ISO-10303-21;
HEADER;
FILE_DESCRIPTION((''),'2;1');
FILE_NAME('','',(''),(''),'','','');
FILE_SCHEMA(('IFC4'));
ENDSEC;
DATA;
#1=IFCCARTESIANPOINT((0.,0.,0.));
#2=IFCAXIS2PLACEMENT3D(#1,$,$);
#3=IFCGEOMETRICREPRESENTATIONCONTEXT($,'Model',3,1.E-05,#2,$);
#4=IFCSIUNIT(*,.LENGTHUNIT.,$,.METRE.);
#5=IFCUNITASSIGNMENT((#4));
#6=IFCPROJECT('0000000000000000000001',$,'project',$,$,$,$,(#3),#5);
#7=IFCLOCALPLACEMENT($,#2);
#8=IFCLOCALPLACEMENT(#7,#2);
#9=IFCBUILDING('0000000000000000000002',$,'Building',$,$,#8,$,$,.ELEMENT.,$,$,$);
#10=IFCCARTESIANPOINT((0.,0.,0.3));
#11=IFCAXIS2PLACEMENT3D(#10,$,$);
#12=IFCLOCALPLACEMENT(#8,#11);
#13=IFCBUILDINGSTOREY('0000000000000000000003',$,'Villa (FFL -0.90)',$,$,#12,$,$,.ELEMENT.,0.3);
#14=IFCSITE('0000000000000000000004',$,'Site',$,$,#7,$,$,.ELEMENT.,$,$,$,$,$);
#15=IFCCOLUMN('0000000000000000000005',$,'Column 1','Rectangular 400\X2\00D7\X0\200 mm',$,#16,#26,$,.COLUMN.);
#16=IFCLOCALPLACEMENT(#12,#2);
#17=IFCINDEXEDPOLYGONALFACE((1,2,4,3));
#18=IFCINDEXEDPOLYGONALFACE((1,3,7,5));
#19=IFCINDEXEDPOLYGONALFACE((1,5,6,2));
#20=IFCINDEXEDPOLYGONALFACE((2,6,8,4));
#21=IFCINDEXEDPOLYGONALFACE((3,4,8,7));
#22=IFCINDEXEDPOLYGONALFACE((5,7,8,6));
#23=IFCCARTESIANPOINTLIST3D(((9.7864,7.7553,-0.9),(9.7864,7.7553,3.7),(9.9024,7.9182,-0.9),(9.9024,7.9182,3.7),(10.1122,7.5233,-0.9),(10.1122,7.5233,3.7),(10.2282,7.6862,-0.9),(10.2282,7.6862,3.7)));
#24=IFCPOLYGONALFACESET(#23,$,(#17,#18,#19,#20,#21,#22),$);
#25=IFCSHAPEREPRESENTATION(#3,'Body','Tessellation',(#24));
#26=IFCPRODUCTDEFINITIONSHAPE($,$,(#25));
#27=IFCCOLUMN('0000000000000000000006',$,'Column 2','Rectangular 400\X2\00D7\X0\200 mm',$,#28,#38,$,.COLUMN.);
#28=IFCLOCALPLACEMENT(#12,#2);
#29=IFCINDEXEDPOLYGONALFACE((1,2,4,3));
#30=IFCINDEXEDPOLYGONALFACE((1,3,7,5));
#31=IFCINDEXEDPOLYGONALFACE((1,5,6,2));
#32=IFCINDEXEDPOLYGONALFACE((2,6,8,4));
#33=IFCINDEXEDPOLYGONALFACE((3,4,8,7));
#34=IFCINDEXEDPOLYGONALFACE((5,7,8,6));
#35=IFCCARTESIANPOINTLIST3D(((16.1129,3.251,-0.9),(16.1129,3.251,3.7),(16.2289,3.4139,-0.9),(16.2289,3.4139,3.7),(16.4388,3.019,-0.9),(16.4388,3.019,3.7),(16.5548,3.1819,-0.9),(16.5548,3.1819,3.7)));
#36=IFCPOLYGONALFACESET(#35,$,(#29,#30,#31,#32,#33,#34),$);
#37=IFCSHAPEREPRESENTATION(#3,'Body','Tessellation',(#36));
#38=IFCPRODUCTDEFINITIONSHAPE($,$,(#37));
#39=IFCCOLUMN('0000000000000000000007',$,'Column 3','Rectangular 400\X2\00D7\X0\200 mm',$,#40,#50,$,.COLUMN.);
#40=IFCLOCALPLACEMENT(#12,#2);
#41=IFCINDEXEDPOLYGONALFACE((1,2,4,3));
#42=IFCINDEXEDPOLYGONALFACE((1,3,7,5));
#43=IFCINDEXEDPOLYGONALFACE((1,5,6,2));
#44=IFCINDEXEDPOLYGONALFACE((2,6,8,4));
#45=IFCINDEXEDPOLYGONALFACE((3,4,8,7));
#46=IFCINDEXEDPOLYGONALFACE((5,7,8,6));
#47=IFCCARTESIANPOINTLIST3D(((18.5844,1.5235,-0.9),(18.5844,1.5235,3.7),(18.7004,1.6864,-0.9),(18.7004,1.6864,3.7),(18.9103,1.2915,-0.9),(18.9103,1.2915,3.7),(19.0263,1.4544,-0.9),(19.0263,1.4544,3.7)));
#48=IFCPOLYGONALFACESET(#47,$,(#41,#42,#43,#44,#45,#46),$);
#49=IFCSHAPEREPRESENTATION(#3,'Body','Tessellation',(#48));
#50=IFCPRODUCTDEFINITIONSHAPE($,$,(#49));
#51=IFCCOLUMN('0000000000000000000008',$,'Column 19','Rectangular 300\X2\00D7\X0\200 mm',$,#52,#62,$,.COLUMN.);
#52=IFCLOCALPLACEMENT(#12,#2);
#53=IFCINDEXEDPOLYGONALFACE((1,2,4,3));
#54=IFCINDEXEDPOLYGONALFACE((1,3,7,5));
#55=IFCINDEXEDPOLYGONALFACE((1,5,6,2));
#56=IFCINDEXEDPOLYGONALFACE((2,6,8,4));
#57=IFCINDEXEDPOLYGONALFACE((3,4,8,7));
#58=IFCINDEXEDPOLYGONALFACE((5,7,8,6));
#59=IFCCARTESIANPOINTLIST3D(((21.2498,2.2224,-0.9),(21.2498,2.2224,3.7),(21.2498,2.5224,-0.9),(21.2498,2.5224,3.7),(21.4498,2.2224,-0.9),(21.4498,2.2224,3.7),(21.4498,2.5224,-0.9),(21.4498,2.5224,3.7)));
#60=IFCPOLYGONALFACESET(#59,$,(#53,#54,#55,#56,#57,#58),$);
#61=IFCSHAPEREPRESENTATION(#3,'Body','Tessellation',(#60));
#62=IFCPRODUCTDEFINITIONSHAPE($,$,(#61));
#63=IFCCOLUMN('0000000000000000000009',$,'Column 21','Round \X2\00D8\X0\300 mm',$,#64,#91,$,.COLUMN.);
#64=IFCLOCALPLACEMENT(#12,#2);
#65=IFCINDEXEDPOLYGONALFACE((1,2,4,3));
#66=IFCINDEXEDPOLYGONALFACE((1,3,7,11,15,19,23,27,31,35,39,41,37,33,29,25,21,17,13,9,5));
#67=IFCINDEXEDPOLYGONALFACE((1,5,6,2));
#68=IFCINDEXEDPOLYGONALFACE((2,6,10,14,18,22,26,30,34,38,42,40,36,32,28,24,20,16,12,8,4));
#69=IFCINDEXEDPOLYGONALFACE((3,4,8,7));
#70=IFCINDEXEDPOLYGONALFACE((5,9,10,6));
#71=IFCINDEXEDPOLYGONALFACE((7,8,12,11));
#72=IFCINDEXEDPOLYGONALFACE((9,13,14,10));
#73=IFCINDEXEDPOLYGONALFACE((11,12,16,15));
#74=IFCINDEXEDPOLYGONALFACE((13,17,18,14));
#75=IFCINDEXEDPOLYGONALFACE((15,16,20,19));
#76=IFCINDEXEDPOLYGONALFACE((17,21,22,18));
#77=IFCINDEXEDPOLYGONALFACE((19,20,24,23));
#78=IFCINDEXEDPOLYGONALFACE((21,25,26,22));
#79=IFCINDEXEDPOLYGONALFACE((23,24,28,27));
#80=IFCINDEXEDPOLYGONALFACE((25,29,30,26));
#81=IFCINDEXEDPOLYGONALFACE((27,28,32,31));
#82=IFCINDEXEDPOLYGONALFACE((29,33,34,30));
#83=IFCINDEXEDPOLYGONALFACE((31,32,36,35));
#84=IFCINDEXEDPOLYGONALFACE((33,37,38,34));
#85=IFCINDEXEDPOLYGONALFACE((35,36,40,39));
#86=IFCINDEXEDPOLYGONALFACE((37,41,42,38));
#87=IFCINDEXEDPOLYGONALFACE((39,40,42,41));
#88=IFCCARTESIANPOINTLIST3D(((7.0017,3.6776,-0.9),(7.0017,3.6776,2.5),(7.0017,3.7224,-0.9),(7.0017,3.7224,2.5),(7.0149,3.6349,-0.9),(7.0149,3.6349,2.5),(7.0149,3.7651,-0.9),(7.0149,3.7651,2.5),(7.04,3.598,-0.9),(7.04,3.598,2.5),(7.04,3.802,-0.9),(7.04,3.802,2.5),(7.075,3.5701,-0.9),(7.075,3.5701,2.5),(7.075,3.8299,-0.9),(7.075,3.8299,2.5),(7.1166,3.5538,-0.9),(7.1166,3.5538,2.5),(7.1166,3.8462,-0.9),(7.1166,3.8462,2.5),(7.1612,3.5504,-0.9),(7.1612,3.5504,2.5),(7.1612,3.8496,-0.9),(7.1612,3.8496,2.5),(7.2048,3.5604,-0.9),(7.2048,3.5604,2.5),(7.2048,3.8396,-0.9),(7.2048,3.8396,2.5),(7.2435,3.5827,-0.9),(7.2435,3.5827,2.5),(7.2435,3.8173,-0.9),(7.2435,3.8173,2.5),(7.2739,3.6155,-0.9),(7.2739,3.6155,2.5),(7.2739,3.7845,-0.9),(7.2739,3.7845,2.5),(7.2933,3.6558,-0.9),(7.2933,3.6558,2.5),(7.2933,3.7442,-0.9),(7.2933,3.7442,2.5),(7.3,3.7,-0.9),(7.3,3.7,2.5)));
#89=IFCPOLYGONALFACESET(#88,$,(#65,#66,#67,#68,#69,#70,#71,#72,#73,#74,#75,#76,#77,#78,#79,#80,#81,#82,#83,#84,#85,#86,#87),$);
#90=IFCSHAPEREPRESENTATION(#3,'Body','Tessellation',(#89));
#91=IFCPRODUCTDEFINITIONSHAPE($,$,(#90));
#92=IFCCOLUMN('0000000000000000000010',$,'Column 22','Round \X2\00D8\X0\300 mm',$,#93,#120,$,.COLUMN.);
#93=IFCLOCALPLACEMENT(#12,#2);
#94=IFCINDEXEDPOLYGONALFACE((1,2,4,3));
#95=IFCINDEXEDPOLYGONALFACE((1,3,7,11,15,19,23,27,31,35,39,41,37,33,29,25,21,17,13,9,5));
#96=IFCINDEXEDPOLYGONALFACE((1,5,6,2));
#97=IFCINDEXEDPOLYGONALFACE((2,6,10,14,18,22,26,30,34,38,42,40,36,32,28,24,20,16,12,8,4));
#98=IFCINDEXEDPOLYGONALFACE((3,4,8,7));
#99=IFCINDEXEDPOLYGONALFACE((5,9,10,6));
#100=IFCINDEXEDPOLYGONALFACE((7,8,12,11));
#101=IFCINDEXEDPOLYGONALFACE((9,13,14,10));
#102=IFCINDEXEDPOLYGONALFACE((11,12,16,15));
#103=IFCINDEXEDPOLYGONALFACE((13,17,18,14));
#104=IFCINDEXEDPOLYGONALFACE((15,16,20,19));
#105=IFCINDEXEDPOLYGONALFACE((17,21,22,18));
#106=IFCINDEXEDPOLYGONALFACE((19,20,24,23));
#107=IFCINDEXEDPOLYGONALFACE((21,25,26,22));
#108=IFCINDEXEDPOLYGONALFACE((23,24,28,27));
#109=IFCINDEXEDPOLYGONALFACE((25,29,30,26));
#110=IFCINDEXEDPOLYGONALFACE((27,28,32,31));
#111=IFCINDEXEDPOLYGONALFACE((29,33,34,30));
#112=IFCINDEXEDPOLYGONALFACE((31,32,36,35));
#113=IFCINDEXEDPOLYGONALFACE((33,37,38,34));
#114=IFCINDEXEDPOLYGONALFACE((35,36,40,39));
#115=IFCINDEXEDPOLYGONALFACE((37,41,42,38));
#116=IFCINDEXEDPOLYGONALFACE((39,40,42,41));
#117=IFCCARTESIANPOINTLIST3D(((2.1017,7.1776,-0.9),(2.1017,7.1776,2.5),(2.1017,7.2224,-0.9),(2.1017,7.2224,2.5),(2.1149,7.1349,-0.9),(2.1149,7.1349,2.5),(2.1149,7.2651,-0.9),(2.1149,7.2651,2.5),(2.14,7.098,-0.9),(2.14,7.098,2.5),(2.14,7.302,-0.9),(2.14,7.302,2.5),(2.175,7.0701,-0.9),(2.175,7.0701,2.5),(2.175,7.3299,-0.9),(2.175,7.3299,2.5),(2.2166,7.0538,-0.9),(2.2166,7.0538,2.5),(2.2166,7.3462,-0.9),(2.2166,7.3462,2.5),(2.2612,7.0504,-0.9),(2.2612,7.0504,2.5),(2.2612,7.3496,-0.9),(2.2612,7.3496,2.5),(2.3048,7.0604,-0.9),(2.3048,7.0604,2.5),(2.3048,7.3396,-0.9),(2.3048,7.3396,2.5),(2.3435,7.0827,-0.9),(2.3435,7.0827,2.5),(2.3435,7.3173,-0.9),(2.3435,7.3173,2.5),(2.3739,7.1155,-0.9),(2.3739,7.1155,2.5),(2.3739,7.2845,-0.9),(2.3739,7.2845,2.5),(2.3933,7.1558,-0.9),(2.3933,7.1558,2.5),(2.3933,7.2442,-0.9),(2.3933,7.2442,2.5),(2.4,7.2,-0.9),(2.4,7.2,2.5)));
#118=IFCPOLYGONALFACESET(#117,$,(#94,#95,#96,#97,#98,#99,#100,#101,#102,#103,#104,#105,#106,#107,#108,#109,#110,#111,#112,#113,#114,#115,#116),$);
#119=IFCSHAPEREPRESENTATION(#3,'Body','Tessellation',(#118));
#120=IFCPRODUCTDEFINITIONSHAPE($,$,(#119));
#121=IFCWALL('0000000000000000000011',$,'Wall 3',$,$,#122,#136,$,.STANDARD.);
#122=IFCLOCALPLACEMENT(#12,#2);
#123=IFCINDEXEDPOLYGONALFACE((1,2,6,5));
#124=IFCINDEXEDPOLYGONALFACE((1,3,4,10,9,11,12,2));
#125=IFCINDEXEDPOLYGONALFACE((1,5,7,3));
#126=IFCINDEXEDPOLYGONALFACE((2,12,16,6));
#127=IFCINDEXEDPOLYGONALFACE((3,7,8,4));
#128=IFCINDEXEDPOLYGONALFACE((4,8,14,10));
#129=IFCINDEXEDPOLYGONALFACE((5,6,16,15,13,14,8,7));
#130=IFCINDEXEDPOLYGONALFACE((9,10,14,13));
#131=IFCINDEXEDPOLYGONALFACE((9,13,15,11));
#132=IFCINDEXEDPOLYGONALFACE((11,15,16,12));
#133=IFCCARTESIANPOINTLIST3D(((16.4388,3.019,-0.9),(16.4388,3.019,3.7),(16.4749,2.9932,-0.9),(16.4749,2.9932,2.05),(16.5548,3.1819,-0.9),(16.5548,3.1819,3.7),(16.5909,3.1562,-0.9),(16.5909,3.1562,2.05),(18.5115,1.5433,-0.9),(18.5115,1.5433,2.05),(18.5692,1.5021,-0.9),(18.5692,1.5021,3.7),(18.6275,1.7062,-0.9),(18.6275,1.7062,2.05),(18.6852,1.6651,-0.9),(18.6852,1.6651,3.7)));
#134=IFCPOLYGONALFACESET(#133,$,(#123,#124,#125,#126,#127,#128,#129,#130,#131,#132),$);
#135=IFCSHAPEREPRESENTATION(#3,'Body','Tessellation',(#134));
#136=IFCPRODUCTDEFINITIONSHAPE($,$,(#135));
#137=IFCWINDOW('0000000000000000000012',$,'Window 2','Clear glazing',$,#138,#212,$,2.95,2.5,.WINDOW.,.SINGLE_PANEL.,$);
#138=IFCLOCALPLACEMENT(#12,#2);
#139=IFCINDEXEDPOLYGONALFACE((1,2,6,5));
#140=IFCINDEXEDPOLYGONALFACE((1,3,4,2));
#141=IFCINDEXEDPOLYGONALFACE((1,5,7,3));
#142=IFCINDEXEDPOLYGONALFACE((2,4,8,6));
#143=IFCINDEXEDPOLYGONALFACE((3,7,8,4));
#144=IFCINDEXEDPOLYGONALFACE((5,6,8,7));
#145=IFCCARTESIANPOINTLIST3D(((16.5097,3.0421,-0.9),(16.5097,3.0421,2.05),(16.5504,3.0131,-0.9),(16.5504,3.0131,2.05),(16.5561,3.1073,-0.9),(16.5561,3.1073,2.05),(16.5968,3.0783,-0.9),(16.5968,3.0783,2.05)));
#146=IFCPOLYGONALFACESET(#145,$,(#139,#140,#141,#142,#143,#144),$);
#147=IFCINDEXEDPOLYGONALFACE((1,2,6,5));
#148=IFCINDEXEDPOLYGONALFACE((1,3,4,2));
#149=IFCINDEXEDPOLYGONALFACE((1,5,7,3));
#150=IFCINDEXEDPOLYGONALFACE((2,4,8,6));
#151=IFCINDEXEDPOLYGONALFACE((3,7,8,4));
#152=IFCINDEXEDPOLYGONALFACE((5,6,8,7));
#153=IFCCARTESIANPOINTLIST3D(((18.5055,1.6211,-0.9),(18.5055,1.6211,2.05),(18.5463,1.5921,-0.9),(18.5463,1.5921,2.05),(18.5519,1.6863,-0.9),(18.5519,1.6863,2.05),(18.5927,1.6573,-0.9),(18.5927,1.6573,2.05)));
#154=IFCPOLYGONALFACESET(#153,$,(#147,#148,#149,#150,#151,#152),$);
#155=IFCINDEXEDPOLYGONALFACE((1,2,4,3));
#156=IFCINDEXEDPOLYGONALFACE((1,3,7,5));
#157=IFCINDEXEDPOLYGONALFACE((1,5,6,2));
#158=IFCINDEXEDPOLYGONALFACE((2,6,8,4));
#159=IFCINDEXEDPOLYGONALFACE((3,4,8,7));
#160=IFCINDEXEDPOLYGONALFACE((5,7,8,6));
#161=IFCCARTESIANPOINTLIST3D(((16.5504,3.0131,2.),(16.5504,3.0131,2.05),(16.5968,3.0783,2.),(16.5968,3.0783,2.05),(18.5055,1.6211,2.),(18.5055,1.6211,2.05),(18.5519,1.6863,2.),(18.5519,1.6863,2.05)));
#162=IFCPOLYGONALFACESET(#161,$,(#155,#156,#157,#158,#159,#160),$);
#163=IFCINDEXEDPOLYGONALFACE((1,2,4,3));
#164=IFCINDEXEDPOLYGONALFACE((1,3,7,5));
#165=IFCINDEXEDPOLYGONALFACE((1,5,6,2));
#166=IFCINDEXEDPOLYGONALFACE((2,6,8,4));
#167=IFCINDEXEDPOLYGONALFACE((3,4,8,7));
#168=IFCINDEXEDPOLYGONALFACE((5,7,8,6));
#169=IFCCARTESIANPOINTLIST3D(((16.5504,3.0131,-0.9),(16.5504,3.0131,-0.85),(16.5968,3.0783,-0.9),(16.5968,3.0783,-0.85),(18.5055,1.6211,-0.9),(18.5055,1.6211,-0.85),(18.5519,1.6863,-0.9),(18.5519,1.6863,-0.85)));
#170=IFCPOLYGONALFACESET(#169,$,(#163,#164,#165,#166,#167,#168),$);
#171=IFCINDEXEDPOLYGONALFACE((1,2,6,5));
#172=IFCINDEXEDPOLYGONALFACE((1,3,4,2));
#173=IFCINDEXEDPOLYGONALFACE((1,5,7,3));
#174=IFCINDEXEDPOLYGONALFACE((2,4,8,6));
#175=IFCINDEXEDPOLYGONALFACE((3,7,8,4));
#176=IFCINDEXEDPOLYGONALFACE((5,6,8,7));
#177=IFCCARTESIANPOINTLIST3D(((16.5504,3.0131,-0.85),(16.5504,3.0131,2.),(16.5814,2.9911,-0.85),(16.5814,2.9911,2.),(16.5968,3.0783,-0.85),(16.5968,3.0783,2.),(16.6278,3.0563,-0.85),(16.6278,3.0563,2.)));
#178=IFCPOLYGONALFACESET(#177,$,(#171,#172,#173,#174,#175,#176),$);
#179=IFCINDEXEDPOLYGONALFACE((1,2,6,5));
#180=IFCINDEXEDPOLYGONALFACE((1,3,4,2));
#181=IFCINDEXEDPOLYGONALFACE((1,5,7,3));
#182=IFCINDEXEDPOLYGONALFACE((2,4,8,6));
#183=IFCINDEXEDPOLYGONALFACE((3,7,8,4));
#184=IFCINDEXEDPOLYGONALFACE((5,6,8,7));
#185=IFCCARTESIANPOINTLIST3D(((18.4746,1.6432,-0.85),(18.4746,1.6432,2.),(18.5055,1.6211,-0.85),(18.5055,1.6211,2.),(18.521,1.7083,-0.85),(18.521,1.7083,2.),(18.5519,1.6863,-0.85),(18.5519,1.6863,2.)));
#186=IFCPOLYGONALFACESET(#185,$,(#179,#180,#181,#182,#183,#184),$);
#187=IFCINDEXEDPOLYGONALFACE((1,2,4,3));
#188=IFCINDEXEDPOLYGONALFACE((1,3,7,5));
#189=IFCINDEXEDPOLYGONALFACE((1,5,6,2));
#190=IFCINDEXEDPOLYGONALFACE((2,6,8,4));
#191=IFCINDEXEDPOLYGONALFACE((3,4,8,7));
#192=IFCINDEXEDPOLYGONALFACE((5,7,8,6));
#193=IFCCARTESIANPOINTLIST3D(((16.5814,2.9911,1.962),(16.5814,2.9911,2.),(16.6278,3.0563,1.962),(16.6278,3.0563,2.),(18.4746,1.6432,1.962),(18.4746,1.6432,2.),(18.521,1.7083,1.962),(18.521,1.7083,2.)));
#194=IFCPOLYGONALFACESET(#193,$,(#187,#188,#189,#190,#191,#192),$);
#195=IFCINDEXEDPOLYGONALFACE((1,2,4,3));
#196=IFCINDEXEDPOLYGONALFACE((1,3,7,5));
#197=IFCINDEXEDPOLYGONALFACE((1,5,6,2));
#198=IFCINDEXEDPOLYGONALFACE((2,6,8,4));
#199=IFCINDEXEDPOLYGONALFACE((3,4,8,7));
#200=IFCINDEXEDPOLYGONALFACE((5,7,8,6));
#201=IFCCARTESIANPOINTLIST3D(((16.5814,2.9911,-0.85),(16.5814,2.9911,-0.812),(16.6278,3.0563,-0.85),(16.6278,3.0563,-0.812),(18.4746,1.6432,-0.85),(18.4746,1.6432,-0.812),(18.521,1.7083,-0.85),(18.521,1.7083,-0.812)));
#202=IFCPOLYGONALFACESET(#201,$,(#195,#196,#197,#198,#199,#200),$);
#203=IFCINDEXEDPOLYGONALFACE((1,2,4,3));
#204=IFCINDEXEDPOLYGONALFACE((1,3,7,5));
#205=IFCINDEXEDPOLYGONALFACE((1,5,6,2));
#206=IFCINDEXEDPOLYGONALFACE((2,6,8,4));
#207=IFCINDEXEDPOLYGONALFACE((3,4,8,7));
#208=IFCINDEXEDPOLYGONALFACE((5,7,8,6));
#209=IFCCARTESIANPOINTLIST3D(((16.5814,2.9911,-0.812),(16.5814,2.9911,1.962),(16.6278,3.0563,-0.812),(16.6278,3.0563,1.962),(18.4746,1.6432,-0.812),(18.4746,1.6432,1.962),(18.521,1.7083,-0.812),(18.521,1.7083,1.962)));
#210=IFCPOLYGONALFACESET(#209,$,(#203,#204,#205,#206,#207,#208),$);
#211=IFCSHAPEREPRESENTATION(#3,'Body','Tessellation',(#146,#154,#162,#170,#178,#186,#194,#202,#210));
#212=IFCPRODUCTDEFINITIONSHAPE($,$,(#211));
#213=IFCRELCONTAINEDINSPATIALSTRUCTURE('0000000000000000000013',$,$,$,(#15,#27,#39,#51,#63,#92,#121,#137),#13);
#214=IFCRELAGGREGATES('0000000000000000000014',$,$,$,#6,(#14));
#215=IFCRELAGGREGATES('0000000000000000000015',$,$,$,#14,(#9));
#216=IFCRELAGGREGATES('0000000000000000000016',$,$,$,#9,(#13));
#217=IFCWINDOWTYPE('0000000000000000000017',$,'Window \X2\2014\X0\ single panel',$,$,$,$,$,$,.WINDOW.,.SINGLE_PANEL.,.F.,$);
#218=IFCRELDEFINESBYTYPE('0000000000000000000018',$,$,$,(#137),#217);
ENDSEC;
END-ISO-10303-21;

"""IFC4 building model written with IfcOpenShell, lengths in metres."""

from ifc_helpers import new_model, si_unit, frame, frame_2d, origin, origin_2d, place, context, project, spatial, polyline, rectangle, circle, outline, extrude, type_object, element, fill, save


model = new_model("IFC4")

# Units and contexts
model_context = context("Model", 3, precision=1e-05, world=origin())
ifc_project = project(units=[si_unit("LENGTHUNIT", "METRE")], contexts=[model_context])

# Site, building, storey
site_placement = place(None, origin())
site = spatial("IfcSite", under=ifc_project, at=site_placement, Name="Site", CompositionType="ELEMENT")
building_placement = place(site_placement, origin())
building = spatial("IfcBuilding", under=site, at=building_placement, Name="Building", CompositionType="ELEMENT")
storey_placement = place(building_placement, frame((0.0, 0.0, 0.3)))
storey = spatial("IfcBuildingStorey", under=building, at=storey_placement, Name="Villa (FFL -0.90)", CompositionType="ELEMENT", Elevation=0.3)

# Columns
for number, where, z_axis, x_axis, name in (
    (1, (10.0073, 7.7208, -0.9), (0.0, 0.0, 1.0), (0.814622, -0.579992, 0.0), "Column 1"),
    (2, (16.3339, 3.2164, -0.9), (0.0, 0.0, 1.0), (0.814622, -0.579992, 0.0), "Column 2"),
    (3, (18.8054, 1.489, -0.9), (0.0, 0.0, 1.0), (0.814622, -0.579992, 0.0), "Column 3"),
):
    element("IfcColumn", number, at=place(storey_placement, frame(where, z_axis=z_axis, x_axis=x_axis)), inside=storey, Name=name, Description="Rectangular 400×200 mm", PredefinedType="COLUMN", context=model_context, shape_type="SweptSolid", body=[
        extrude(outline(polyline([(-0.2, -0.1), (0.2, -0.1), (0.2, 0.1), (-0.2, 0.1), (-0.2, -0.1)])), origin(), (0.0, 0.0, 1.0), 4.6),
    ])
column_placement = place(storey_placement, frame((21.3498, 2.3724, -0.9), z_axis=(0.0, 0.0, 1.0), x_axis=(0.0, 1.0, 0.0)))
element("IfcColumn", 4, at=column_placement, inside=storey, Name="Column 19", Description="Rectangular 300×200 mm", PredefinedType="COLUMN", context=model_context, shape_type="SweptSolid", body=[
    extrude(outline(polyline([(-0.15, -0.1), (0.15, -0.1), (0.15, 0.1), (-0.15, 0.1), (-0.15, -0.1)])), origin(), (0.0, 0.0, 1.0), 4.6),
])
for number, where, z_axis, x_axis, name in (
    (5, (7.15, 3.7, -0.9), (0.0, 0.0, 1.0), (1.0, 0.0, 0.0), "Column 21"),
    (6, (2.25, 7.2, -0.9), (0.0, 0.0, 1.0), (1.0, 0.0, 0.0), "Column 22"),
):
    element("IfcColumn", number, at=place(storey_placement, frame(where, z_axis=z_axis, x_axis=x_axis)), inside=storey, Name=name, Description="Round Ø300 mm", PredefinedType="COLUMN", context=model_context, shape_type="SweptSolid", body=[
        extrude(circle(Radius=0.15, at=origin_2d()), origin(), (0.0, 0.0, 1.0), 3.4),
    ])

# Wall, opening, window
wall_1_placement = place(storey_placement, frame((16.4968, 3.1004, -0.9), z_axis=(0.0, 0.0, 1.0), x_axis=(0.814622, -0.579992, 0.0)))
wall_1 = element("IfcWall", 7, at=wall_1_placement, inside=storey, Name="Wall 3", PredefinedType="STANDARD", context=model_context, shape_type="SweptSolid", body=[
    extrude(rectangle(XDim=2.6152, YDim=0.2, at=frame_2d((1.3076, 0.0))), origin(), (0.0, 0.0, 1.0), 4.6),
])
opening_1_placement = place(storey_placement, frame((16.5329, 3.0747, -0.9), z_axis=(0.0, 0.0, 1.0), x_axis=(0.814622, -0.579992, 0.0)))
opening_1 = element("IfcOpeningElement", 8, at=opening_1_placement, cuts=wall_1, PredefinedType="OPENING", context=model_context, shape_type="SweptSolid", body=[
    extrude(rectangle(XDim=2.5, YDim=0.26, at=frame_2d((1.25, 0.0))), origin(), (0.0, 0.0, 1.0), 2.95),
])
window_type = type_object("IfcWindowType", Name="Window — single panel", ParameterTakesPrecedence=False, PartitioningType="SINGLE_PANEL", PredefinedType="WINDOW")
window_placement = place(storey_placement, frame((16.5329, 3.0747, -0.9), z_axis=(0.0, 0.0, 1.0), x_axis=(0.814622, -0.579992, 0.0)))
window = element("IfcWindow", 9, at=window_placement, inside=storey, type_object=window_type, Name="Window 2", Description="Clear glazing", OverallHeight=2.95, OverallWidth=2.5, PartitioningType="SINGLE_PANEL", PredefinedType="WINDOW", context=model_context, shape_type="SweptSolid", body=[
    extrude(rectangle(XDim=0.05, YDim=0.08, at=frame_2d((0.025, 0.0))), origin(), (0.0, 0.0, 1.0), 2.95),
    extrude(rectangle(XDim=0.05, YDim=0.08, at=frame_2d((2.475, 0.0))), origin(), (0.0, 0.0, 1.0), 2.95),
    extrude(rectangle(XDim=2.4, YDim=0.08, at=frame_2d((1.25, 0.0))), frame((0.0, 0.0, 2.9)), (0.0, 0.0, 1.0), 0.05),
    extrude(rectangle(XDim=2.4, YDim=0.08, at=frame_2d((1.25, 0.0))), origin(), (0.0, 0.0, 1.0), 0.05),
    extrude(rectangle(XDim=0.038, YDim=0.08, at=frame_2d((0.069, 0.0))), frame((0.0, 0.0, 0.05)), (0.0, 0.0, 1.0), 2.85),
    extrude(rectangle(XDim=0.038, YDim=0.08, at=frame_2d((2.431, 0.0))), frame((0.0, 0.0, 0.05)), (0.0, 0.0, 1.0), 2.85),
    extrude(rectangle(XDim=2.324, YDim=0.08, at=frame_2d((1.25, 0.0))), frame((0.0, 0.0, 2.862)), (0.0, 0.0, 1.0), 0.038),
    extrude(rectangle(XDim=2.324, YDim=0.08, at=frame_2d((1.25, 0.0))), frame((0.0, 0.0, 0.05)), (0.0, 0.0, 1.0), 0.038),
    extrude(rectangle(XDim=2.324, YDim=0.08, at=frame_2d((1.25, 0.0))), frame((0.0, 0.0, 0.088)), (0.0, 0.0, 1.0), 2.774),
])
fill(opening_1, window)

save(model, "model.ifc")
